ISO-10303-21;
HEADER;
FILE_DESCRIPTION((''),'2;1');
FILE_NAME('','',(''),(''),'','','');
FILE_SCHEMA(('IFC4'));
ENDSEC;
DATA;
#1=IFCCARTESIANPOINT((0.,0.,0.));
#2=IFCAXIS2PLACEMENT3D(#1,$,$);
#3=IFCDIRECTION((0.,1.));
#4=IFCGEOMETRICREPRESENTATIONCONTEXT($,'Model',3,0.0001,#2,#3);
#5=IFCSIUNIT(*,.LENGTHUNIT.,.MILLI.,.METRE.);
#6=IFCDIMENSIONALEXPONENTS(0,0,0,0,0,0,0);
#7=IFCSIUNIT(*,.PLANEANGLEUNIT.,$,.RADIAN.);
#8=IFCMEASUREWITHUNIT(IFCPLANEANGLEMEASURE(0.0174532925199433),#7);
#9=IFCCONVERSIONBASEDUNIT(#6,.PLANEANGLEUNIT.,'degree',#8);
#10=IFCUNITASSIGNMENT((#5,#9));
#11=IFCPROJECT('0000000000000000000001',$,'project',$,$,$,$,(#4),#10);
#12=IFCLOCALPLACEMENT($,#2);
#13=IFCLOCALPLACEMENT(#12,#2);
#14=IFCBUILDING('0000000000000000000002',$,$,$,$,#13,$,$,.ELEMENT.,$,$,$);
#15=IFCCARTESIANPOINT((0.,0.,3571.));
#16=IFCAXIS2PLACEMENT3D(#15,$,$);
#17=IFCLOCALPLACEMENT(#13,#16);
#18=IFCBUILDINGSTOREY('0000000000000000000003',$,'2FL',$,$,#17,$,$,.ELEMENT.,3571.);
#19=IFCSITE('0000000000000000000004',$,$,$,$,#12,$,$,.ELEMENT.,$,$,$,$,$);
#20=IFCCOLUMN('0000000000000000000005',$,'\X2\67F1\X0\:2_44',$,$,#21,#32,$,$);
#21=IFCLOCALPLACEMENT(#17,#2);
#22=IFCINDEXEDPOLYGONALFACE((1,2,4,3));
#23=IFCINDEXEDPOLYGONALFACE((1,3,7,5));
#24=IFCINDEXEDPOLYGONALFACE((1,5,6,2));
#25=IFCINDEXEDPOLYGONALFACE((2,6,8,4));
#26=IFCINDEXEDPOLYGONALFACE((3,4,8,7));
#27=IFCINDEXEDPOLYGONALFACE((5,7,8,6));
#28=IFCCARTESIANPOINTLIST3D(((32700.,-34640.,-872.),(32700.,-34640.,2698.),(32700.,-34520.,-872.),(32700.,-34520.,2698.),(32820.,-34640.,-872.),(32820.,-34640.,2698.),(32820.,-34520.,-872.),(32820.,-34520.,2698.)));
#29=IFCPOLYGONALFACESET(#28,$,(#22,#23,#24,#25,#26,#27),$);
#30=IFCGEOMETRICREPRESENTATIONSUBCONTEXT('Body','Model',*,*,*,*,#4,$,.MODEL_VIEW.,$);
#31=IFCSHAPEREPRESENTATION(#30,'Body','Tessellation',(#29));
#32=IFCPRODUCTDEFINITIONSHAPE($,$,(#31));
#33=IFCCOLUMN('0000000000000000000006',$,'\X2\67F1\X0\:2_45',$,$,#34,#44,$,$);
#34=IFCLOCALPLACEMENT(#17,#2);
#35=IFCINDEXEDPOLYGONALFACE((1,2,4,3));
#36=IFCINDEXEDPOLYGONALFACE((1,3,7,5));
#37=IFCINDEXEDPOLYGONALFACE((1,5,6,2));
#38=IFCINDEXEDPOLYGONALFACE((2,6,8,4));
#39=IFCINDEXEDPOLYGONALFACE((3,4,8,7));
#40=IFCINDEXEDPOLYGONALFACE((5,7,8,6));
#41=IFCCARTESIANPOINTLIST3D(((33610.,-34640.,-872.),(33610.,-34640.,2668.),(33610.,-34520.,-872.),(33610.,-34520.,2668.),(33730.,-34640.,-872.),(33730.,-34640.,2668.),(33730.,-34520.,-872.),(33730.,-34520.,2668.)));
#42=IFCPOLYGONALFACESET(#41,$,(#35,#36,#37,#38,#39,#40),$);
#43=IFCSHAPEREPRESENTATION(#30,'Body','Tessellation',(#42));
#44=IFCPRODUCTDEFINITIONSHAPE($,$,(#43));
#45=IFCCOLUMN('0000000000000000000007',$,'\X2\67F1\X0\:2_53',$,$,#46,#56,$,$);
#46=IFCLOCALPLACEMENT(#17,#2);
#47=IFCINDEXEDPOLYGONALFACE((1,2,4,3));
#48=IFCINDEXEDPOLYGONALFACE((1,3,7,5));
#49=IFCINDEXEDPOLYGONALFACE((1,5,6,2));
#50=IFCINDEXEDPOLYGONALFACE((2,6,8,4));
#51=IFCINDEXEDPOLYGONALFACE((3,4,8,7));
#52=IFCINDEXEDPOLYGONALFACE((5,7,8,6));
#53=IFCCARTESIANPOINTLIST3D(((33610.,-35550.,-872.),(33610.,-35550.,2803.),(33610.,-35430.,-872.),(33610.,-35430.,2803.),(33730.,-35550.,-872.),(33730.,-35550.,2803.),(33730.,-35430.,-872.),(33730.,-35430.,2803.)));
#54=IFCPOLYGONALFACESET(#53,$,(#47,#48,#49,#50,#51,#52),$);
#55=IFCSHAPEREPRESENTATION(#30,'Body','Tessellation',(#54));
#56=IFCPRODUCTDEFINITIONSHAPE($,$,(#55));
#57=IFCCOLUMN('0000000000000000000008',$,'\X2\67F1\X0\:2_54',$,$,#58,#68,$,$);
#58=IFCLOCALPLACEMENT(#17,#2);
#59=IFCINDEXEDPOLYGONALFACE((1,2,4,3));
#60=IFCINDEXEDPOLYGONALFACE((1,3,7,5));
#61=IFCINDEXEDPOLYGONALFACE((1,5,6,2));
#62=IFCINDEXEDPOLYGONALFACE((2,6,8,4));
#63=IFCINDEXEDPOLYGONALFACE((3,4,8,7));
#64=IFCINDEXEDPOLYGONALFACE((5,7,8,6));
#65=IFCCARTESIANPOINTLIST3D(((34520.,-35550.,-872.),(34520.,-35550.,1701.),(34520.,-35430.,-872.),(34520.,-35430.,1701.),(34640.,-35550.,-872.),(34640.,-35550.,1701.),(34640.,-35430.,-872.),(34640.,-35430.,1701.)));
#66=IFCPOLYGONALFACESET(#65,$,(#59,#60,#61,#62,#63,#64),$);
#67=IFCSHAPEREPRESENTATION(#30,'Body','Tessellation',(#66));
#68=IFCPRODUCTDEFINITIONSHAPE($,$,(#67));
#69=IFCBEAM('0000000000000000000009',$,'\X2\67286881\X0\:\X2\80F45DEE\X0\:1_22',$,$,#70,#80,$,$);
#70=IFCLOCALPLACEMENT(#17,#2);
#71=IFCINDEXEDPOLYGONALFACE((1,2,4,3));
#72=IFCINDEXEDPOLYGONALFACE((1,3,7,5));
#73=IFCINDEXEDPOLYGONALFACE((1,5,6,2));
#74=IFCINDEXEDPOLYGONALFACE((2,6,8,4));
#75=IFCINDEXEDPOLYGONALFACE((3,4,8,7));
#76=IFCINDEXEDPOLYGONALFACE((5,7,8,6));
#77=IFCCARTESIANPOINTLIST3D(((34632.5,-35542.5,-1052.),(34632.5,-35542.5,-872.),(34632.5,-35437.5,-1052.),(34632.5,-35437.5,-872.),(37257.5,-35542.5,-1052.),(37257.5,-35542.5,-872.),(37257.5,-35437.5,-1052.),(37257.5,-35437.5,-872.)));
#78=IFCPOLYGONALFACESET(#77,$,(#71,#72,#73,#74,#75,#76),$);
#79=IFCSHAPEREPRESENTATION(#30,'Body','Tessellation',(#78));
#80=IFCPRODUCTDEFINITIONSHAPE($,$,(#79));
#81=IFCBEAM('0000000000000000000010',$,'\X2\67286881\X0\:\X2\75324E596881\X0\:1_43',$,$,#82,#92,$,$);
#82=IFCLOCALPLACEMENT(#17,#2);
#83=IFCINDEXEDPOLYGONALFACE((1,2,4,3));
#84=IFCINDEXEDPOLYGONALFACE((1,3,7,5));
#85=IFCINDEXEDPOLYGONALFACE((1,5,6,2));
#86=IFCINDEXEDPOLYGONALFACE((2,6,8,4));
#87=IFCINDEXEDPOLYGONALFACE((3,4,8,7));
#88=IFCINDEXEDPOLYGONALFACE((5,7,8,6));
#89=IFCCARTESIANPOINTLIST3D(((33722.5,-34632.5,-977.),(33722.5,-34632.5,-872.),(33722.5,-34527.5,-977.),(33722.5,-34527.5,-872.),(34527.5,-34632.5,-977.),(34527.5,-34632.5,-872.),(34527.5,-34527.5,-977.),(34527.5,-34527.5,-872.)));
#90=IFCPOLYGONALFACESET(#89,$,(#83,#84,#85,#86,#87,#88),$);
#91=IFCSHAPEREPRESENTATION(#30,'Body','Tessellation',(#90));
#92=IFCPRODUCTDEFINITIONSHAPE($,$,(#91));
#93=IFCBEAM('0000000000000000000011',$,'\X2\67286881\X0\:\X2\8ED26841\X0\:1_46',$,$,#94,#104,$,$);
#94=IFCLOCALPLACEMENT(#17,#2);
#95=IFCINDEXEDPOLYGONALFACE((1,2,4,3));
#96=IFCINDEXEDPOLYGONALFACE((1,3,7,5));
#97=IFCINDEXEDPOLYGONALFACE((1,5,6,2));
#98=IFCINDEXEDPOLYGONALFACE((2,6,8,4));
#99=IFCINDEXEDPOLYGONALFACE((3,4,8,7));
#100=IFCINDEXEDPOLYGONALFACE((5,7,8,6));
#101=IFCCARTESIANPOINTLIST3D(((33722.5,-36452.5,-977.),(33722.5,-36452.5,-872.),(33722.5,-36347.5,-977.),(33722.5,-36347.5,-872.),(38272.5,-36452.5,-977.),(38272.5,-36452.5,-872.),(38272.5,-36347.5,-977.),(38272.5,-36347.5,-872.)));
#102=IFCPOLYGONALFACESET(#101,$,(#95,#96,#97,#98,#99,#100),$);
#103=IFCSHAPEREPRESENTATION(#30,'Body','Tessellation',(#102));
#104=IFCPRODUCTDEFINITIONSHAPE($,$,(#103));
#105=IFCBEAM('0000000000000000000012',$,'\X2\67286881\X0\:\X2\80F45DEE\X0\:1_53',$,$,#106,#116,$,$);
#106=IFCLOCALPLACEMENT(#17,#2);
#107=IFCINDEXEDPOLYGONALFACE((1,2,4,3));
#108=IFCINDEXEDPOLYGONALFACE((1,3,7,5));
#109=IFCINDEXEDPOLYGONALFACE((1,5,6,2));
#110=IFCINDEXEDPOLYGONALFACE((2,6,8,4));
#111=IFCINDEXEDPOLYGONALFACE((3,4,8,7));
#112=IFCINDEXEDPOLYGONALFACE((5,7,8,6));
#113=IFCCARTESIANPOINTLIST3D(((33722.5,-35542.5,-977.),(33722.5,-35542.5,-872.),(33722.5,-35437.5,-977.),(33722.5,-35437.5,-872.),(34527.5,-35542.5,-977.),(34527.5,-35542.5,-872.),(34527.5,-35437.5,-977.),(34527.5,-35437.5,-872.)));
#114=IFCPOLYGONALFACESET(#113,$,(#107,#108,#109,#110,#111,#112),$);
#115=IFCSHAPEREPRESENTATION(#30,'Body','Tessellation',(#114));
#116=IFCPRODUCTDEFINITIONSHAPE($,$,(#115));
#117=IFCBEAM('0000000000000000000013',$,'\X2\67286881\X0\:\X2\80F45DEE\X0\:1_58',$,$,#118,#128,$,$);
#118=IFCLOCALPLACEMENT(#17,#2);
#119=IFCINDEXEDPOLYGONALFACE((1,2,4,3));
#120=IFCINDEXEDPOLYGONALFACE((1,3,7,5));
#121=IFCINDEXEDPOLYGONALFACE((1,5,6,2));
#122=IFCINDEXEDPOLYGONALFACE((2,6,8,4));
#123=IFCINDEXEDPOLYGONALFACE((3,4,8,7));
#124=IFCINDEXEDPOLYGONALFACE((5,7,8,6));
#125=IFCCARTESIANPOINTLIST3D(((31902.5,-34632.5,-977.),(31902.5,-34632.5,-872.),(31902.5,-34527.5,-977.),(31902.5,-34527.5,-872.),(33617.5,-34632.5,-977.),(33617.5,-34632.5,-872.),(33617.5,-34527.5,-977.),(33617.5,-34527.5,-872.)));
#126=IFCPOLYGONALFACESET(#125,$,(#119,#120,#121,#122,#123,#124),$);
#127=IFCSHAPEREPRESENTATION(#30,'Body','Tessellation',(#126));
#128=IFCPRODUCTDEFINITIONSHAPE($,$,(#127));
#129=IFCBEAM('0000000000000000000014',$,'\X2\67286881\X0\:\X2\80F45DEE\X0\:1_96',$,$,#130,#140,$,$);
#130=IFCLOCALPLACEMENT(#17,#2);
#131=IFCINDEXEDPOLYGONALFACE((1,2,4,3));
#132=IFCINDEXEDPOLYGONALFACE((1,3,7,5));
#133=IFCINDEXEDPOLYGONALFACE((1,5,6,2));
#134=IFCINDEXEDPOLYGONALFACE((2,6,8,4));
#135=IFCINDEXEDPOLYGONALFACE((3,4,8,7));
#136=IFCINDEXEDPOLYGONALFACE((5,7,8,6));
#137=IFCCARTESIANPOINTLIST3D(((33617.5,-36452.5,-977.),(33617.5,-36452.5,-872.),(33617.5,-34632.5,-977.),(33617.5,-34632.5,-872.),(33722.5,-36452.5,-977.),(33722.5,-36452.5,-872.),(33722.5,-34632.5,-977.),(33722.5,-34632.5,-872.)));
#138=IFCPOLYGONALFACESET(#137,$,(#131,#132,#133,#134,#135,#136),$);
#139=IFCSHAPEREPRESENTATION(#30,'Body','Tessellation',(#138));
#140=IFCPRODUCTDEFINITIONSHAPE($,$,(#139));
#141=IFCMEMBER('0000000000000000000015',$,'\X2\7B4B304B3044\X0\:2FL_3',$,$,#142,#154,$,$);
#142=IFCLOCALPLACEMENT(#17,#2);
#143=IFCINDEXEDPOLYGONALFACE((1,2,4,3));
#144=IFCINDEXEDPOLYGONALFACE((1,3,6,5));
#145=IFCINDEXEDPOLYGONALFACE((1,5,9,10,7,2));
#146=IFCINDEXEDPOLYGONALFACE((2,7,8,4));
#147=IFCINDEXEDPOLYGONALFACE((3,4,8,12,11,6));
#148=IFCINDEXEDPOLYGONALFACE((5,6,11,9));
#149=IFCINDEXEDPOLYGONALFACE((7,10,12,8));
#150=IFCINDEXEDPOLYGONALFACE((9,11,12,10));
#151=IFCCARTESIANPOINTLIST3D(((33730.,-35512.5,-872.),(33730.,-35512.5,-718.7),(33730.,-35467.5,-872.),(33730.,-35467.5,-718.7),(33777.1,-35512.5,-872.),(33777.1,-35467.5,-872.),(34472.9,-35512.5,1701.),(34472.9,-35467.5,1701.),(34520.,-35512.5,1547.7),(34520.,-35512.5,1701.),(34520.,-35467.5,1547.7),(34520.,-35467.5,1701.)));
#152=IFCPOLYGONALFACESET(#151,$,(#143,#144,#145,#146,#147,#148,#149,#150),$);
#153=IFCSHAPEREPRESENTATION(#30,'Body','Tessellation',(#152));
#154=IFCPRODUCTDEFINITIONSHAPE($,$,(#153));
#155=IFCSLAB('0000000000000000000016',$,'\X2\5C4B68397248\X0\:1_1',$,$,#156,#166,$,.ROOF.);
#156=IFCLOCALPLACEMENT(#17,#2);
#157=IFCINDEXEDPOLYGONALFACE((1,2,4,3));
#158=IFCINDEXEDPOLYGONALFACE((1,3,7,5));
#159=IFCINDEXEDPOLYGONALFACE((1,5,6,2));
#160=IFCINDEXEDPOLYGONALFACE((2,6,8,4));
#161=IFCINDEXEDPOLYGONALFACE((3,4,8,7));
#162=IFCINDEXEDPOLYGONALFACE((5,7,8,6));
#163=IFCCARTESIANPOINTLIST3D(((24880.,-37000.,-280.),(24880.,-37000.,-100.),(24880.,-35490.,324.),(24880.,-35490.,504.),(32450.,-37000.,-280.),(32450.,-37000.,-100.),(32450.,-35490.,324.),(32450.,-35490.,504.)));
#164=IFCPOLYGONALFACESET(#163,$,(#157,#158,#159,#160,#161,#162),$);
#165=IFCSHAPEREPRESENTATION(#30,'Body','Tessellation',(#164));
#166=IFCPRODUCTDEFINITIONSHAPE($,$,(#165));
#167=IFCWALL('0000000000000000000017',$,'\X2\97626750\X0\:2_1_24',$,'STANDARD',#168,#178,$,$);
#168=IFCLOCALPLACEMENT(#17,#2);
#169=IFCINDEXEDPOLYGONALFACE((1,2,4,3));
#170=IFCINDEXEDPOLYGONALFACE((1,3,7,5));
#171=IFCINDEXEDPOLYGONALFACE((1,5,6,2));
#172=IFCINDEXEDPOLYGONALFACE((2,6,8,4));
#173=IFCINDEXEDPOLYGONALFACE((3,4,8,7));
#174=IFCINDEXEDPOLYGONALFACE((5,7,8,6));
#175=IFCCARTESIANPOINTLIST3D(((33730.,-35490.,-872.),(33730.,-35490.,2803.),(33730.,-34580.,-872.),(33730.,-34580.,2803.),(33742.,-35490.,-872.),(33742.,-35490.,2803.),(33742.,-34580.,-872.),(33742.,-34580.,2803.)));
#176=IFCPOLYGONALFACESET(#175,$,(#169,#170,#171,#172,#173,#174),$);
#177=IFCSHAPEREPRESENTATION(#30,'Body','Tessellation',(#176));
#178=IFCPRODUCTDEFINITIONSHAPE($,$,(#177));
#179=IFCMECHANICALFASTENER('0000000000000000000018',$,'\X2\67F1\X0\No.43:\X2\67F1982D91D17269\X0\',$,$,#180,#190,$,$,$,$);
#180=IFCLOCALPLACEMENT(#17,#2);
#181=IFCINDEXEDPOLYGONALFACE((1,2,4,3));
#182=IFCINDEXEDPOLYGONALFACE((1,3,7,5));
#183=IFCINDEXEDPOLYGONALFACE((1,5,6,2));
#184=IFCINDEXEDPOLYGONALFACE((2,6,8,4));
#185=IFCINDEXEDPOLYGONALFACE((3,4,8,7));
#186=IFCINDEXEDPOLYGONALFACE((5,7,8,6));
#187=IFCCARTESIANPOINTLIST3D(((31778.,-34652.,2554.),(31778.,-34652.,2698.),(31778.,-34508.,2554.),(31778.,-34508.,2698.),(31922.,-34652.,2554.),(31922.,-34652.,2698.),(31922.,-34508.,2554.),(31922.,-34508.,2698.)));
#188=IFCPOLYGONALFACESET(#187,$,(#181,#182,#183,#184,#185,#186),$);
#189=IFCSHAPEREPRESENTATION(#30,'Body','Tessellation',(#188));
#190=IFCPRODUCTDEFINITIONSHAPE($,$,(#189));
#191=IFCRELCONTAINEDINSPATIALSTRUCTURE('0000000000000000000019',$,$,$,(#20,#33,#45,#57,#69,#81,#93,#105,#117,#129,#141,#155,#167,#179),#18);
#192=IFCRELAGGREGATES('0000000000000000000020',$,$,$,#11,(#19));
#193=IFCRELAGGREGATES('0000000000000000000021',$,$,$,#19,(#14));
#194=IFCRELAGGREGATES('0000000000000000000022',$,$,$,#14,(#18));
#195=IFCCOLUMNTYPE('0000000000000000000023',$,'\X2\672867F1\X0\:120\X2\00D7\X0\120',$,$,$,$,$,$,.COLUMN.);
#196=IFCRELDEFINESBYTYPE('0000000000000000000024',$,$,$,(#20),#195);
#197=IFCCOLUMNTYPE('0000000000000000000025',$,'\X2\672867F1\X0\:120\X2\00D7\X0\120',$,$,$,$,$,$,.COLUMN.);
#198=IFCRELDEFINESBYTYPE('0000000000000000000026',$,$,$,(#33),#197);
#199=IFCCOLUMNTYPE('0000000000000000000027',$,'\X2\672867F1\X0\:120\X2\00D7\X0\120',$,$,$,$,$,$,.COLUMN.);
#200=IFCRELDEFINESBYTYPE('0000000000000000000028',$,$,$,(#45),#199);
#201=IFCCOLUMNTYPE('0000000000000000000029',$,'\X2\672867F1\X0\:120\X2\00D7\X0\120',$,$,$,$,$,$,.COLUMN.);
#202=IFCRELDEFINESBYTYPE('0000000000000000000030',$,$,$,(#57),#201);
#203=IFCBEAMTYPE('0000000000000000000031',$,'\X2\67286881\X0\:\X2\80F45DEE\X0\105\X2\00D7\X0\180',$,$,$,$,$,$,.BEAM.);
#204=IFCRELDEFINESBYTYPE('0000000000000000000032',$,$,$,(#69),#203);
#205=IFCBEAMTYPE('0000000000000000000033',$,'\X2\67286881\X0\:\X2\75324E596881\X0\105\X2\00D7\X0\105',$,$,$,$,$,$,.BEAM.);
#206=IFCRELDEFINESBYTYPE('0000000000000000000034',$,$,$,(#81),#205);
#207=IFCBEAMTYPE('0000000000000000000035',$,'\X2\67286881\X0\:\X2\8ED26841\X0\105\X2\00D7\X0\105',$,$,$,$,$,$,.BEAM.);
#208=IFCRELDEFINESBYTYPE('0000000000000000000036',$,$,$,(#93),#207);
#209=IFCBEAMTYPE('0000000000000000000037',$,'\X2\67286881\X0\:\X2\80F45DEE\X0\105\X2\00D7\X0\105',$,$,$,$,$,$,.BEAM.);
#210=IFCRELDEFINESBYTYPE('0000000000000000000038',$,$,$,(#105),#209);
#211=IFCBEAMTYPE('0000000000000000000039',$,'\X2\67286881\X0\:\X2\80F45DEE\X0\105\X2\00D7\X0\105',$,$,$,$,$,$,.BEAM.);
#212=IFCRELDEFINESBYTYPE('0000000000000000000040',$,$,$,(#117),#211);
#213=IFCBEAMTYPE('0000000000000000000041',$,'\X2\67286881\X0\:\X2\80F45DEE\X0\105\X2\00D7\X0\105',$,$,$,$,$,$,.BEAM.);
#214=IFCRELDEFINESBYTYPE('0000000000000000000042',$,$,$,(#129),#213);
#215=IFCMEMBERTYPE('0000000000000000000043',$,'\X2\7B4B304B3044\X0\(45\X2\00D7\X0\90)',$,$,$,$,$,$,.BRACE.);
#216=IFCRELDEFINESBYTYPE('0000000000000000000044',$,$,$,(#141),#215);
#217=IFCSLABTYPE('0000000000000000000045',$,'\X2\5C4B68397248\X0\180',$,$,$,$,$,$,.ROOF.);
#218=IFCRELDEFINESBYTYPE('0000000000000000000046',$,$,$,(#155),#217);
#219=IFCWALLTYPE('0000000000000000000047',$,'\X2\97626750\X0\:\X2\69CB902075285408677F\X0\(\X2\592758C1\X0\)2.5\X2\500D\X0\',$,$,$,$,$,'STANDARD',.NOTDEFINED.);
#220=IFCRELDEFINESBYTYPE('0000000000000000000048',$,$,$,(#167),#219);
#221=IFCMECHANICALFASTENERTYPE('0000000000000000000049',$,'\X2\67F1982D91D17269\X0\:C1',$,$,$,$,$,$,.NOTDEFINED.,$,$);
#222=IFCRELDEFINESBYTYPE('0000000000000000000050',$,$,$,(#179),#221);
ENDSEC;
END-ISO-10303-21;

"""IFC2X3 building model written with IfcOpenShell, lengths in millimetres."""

from ifc_helpers import new_model, entity, si_unit, converted_unit, direction, frame, origin, origin_with_axes, origin_2d, place, context, subcontext, project, spatial, polyline, rectangle, outline, extrude, type_object, element, save


model = new_model("IFC2X3")

# Units and contexts
model_context = context("Model", 3, precision=0.0001, world=origin(), true_north=direction((0.0, 1.0)))
body_context = subcontext(model_context, "Body", "Model", "MODEL_VIEW")
ifc_project = project(units=[si_unit("LENGTHUNIT", "METRE", prefix="MILLI"), converted_unit("PLANEANGLEUNIT", "degree", entity("IfcPlaneAngleMeasure", 0.0174532925199433), si_unit("PLANEANGLEUNIT", "RADIAN"), dimensions=[0, 0, 0, 0, 0, 0, 0])], contexts=[model_context])

# Site, building, storey
site_placement = place(None, origin())
site = spatial("IfcSite", under=ifc_project, at=site_placement, CompositionType="ELEMENT")
building_placement = place(site_placement, origin())
building = spatial("IfcBuilding", under=site, at=building_placement, CompositionType="ELEMENT")
storey_placement = place(building_placement, frame((0.0, 0.0, 3571.0)))
storey = spatial("IfcBuildingStorey", under=building, at=storey_placement, Name="2FL", CompositionType="ELEMENT", Elevation=3571.0)

# Columns
column_type_1 = type_object("IfcColumnType", Name="木柱:120×120", PredefinedType="COLUMN")
column_1_placement = place(storey_placement, frame((32760.0, -34580.0, -872.0)))
element("IfcColumn", 1, at=column_1_placement, inside=storey, type_object=column_type_1, Name="柱:2_44", context=body_context, shape_type="SweptSolid", body=[
    extrude(rectangle(XDim=120.0, YDim=120.0, at=origin_2d()), origin_with_axes(), (0.0, 0.0, 1.0), 3570.0),
])
column_type_2 = type_object("IfcColumnType", Name="木柱:120×120", PredefinedType="COLUMN")
column_2_placement = place(storey_placement, frame((33670.0, -34580.0, -872.0)))
element("IfcColumn", 2, at=column_2_placement, inside=storey, type_object=column_type_2, Name="柱:2_45", context=body_context, shape_type="SweptSolid", body=[
    extrude(rectangle(XDim=120.0, YDim=120.0, at=origin_2d()), origin_with_axes(), (0.0, 0.0, 1.0), 3540.0),
])
column_type_3 = type_object("IfcColumnType", Name="木柱:120×120", PredefinedType="COLUMN")
column_3_placement = place(storey_placement, frame((33670.0, -35490.0, -872.0)))
element("IfcColumn", 3, at=column_3_placement, inside=storey, type_object=column_type_3, Name="柱:2_53", context=body_context, shape_type="SweptSolid", body=[
    extrude(rectangle(XDim=120.0, YDim=120.0, at=origin_2d()), origin_with_axes(), (0.0, 0.0, 1.0), 3675.0),
])
column_type_4 = type_object("IfcColumnType", Name="木柱:120×120", PredefinedType="COLUMN")
column_4_placement = place(storey_placement, frame((34580.0, -35490.0, -872.0)))
element("IfcColumn", 4, at=column_4_placement, inside=storey, type_object=column_type_4, Name="柱:2_54", context=body_context, shape_type="SweptSolid", body=[
    extrude(rectangle(XDim=120.0, YDim=120.0, at=origin_2d()), origin_with_axes(), (0.0, 0.0, 1.0), 2573.0),
])

# Beams
beam_type_1 = type_object("IfcBeamType", Name="木梁:胴差105×180", PredefinedType="BEAM")
beam_1_placement = place(storey_placement, frame((34632.5, -35490.0, -962.0), z_axis=(1.0, 0.0, 0.0), x_axis=(0.0, 1.0, 0.0)))
element("IfcBeam", 5, at=beam_1_placement, inside=storey, type_object=beam_type_1, Name="木梁:胴差:1_22", context=body_context, shape_type="SweptSolid", body=[
    extrude(rectangle(XDim=105.0, YDim=180.0, at=origin_2d()), origin_with_axes(), (0.0, 0.0, 1.0), 2625.0),
])
beam_type_2 = type_object("IfcBeamType", Name="木梁:甲乙梁105×105", PredefinedType="BEAM")
beam_2_placement = place(storey_placement, frame((33722.5, -34580.0, -924.5), z_axis=(1.0, 0.0, 0.0), x_axis=(0.0, 1.0, 0.0)))
element("IfcBeam", 6, at=beam_2_placement, inside=storey, type_object=beam_type_2, Name="木梁:甲乙梁:1_43", context=body_context, shape_type="SweptSolid", body=[
    extrude(rectangle(XDim=105.0, YDim=105.0, at=origin_2d()), origin_with_axes(), (0.0, 0.0, 1.0), 805.0),
])
beam_type_3 = type_object("IfcBeamType", Name="木梁:軒桁105×105", PredefinedType="BEAM")
beam_3_placement = place(storey_placement, frame((33722.5, -36400.0, -924.5), z_axis=(1.0, 0.0, 0.0), x_axis=(0.0, 1.0, 0.0)))
element("IfcBeam", 7, at=beam_3_placement, inside=storey, type_object=beam_type_3, Name="木梁:軒桁:1_46", context=body_context, shape_type="SweptSolid", body=[
    extrude(rectangle(XDim=105.0, YDim=105.0, at=origin_2d()), origin_with_axes(), (0.0, 0.0, 1.0), 4550.0),
])
beam_type_4 = type_object("IfcBeamType", Name="木梁:胴差105×105", PredefinedType="BEAM")
beam_4_placement = place(storey_placement, frame((33722.5, -35490.0, -924.5), z_axis=(1.0, 0.0, 0.0), x_axis=(0.0, 1.0, 0.0)))
element("IfcBeam", 8, at=beam_4_placement, inside=storey, type_object=beam_type_4, Name="木梁:胴差:1_53", context=body_context, shape_type="SweptSolid", body=[
    extrude(rectangle(XDim=105.0, YDim=105.0, at=origin_2d()), origin_with_axes(), (0.0, 0.0, 1.0), 805.0),
])
beam_type_5 = type_object("IfcBeamType", Name="木梁:胴差105×105", PredefinedType="BEAM")
beam_5_placement = place(storey_placement, frame((31902.5, -34580.0, -924.5), z_axis=(1.0, 0.0, 0.0), x_axis=(0.0, 1.0, 0.0)))
element("IfcBeam", 9, at=beam_5_placement, inside=storey, type_object=beam_type_5, Name="木梁:胴差:1_58", context=body_context, shape_type="SweptSolid", body=[
    extrude(rectangle(XDim=105.0, YDim=105.0, at=origin_2d()), origin_with_axes(), (0.0, 0.0, 1.0), 1715.0),
])
beam_type_6 = type_object("IfcBeamType", Name="木梁:胴差105×105", PredefinedType="BEAM")
beam_6_placement = place(storey_placement, frame((33670.0, -34632.5, -924.5), z_axis=(0.0, -1.0, 0.0), x_axis=(1.0, 0.0, 0.0)))
element("IfcBeam", 10, at=beam_6_placement, inside=storey, type_object=beam_type_6, Name="木梁:胴差:1_96", context=body_context, shape_type="SweptSolid", body=[
    extrude(rectangle(XDim=105.0, YDim=105.0, at=origin_2d()), origin_with_axes(), (0.0, 0.0, 1.0), 1820.0),
])

# Member
member_type = type_object("IfcMemberType", Name="筋かい(45×90)", PredefinedType="BRACE")
member_placement = place(storey_placement, frame((33730.0, -35490.0, -872.0), z_axis=(0.293511, 0.0, 0.955956), x_axis=(-0.955956, 0.0, 0.293511)))
element("IfcMember", 11, at=member_placement, inside=storey, type_object=member_type, Name="筋かい:2FL_3", context=body_context, shape_type="SweptSolid", body=[
    extrude(outline(polyline([(0.0, 0.0), (13.8, -45.0), (2545.0, -45.0), (2691.5, 0.0), (2677.7, 45.0), (146.6, 45.0), (0.0, 0.0)])), frame((0.0, -22.5, 0.0), z_axis=(0.0, 1.0, 0.0), x_axis=(0.0, 0.0, 1.0)), (0.0, 0.0, 1.0), 45.0),
])

# Slab
slab_type = type_object("IfcSlabType", Name="屋根版180", PredefinedType="ROOF")
slab_placement = place(storey_placement, frame((32450.0, -35490.0, 324.0), z_axis=(0.0, 0.371391, -0.928477), x_axis=(0.0, -0.928477, -0.371391)))
element("IfcSlab", 12, at=slab_placement, inside=storey, type_object=slab_type, Name="屋根版:1_1", PredefinedType="ROOF", context=body_context, shape_type="SweptSolid", body=[
    extrude(outline(polyline([(0.0, 0.0, 0.0), (1626.3, 0.0, 0.0), (1626.3, 7570.0, 0.0), (0.0, 7570.0, 0.0), (0.0, 0.0, 0.0)])), origin_with_axes(), (-0.371391, 0.0, -0.928477), 180.0),
])

# Wall
wall_type = type_object("IfcWallType", Name="面材:構造用合板(大壁)2.5倍", ElementType="STANDARD", PredefinedType="NOTDEFINED")
wall_placement = place(storey_placement, frame((33742.0, -35035.0, -872.0), z_axis=(-1.0, 0.0, 0.0), x_axis=(0.0, -1.0, 0.0)))
element("IfcWall", 13, at=wall_placement, inside=storey, type_object=wall_type, Name="面材:2_1_24", ObjectType="STANDARD", context=body_context, shape_type="SweptSolid", body=[
    extrude(outline(polyline([(455.0, 0.0, 0.0), (-455.0, 0.0, 0.0), (-455.0, 3675.0, 0.0), (455.0, 3675.0, 0.0), (455.0, 0.0, 0.0)])), origin_with_axes(), (0.0, 0.0, 1.0), 12.0),
])

# Mechanical fastener
mechanical_fastener_type_1 = type_object("IfcMechanicalFastenerType", Name="柱頭金物:C1")
mechanical_fastener_1_placement = place(storey_placement, frame((31850.0, -34580.0, 2554.0)))
element("IfcMechanicalFastener", 14, at=mechanical_fastener_1_placement, inside=storey, type_object=mechanical_fastener_type_1, Name="柱No.43:柱頭金物", context=body_context, shape_type="SweptSolid", body=[
    extrude(rectangle(XDim=144.0, YDim=144.0, at=origin_2d()), origin_with_axes(), (0.0, 0.0, 1.0), 144.0),
])

save(model, "model.ifc")
